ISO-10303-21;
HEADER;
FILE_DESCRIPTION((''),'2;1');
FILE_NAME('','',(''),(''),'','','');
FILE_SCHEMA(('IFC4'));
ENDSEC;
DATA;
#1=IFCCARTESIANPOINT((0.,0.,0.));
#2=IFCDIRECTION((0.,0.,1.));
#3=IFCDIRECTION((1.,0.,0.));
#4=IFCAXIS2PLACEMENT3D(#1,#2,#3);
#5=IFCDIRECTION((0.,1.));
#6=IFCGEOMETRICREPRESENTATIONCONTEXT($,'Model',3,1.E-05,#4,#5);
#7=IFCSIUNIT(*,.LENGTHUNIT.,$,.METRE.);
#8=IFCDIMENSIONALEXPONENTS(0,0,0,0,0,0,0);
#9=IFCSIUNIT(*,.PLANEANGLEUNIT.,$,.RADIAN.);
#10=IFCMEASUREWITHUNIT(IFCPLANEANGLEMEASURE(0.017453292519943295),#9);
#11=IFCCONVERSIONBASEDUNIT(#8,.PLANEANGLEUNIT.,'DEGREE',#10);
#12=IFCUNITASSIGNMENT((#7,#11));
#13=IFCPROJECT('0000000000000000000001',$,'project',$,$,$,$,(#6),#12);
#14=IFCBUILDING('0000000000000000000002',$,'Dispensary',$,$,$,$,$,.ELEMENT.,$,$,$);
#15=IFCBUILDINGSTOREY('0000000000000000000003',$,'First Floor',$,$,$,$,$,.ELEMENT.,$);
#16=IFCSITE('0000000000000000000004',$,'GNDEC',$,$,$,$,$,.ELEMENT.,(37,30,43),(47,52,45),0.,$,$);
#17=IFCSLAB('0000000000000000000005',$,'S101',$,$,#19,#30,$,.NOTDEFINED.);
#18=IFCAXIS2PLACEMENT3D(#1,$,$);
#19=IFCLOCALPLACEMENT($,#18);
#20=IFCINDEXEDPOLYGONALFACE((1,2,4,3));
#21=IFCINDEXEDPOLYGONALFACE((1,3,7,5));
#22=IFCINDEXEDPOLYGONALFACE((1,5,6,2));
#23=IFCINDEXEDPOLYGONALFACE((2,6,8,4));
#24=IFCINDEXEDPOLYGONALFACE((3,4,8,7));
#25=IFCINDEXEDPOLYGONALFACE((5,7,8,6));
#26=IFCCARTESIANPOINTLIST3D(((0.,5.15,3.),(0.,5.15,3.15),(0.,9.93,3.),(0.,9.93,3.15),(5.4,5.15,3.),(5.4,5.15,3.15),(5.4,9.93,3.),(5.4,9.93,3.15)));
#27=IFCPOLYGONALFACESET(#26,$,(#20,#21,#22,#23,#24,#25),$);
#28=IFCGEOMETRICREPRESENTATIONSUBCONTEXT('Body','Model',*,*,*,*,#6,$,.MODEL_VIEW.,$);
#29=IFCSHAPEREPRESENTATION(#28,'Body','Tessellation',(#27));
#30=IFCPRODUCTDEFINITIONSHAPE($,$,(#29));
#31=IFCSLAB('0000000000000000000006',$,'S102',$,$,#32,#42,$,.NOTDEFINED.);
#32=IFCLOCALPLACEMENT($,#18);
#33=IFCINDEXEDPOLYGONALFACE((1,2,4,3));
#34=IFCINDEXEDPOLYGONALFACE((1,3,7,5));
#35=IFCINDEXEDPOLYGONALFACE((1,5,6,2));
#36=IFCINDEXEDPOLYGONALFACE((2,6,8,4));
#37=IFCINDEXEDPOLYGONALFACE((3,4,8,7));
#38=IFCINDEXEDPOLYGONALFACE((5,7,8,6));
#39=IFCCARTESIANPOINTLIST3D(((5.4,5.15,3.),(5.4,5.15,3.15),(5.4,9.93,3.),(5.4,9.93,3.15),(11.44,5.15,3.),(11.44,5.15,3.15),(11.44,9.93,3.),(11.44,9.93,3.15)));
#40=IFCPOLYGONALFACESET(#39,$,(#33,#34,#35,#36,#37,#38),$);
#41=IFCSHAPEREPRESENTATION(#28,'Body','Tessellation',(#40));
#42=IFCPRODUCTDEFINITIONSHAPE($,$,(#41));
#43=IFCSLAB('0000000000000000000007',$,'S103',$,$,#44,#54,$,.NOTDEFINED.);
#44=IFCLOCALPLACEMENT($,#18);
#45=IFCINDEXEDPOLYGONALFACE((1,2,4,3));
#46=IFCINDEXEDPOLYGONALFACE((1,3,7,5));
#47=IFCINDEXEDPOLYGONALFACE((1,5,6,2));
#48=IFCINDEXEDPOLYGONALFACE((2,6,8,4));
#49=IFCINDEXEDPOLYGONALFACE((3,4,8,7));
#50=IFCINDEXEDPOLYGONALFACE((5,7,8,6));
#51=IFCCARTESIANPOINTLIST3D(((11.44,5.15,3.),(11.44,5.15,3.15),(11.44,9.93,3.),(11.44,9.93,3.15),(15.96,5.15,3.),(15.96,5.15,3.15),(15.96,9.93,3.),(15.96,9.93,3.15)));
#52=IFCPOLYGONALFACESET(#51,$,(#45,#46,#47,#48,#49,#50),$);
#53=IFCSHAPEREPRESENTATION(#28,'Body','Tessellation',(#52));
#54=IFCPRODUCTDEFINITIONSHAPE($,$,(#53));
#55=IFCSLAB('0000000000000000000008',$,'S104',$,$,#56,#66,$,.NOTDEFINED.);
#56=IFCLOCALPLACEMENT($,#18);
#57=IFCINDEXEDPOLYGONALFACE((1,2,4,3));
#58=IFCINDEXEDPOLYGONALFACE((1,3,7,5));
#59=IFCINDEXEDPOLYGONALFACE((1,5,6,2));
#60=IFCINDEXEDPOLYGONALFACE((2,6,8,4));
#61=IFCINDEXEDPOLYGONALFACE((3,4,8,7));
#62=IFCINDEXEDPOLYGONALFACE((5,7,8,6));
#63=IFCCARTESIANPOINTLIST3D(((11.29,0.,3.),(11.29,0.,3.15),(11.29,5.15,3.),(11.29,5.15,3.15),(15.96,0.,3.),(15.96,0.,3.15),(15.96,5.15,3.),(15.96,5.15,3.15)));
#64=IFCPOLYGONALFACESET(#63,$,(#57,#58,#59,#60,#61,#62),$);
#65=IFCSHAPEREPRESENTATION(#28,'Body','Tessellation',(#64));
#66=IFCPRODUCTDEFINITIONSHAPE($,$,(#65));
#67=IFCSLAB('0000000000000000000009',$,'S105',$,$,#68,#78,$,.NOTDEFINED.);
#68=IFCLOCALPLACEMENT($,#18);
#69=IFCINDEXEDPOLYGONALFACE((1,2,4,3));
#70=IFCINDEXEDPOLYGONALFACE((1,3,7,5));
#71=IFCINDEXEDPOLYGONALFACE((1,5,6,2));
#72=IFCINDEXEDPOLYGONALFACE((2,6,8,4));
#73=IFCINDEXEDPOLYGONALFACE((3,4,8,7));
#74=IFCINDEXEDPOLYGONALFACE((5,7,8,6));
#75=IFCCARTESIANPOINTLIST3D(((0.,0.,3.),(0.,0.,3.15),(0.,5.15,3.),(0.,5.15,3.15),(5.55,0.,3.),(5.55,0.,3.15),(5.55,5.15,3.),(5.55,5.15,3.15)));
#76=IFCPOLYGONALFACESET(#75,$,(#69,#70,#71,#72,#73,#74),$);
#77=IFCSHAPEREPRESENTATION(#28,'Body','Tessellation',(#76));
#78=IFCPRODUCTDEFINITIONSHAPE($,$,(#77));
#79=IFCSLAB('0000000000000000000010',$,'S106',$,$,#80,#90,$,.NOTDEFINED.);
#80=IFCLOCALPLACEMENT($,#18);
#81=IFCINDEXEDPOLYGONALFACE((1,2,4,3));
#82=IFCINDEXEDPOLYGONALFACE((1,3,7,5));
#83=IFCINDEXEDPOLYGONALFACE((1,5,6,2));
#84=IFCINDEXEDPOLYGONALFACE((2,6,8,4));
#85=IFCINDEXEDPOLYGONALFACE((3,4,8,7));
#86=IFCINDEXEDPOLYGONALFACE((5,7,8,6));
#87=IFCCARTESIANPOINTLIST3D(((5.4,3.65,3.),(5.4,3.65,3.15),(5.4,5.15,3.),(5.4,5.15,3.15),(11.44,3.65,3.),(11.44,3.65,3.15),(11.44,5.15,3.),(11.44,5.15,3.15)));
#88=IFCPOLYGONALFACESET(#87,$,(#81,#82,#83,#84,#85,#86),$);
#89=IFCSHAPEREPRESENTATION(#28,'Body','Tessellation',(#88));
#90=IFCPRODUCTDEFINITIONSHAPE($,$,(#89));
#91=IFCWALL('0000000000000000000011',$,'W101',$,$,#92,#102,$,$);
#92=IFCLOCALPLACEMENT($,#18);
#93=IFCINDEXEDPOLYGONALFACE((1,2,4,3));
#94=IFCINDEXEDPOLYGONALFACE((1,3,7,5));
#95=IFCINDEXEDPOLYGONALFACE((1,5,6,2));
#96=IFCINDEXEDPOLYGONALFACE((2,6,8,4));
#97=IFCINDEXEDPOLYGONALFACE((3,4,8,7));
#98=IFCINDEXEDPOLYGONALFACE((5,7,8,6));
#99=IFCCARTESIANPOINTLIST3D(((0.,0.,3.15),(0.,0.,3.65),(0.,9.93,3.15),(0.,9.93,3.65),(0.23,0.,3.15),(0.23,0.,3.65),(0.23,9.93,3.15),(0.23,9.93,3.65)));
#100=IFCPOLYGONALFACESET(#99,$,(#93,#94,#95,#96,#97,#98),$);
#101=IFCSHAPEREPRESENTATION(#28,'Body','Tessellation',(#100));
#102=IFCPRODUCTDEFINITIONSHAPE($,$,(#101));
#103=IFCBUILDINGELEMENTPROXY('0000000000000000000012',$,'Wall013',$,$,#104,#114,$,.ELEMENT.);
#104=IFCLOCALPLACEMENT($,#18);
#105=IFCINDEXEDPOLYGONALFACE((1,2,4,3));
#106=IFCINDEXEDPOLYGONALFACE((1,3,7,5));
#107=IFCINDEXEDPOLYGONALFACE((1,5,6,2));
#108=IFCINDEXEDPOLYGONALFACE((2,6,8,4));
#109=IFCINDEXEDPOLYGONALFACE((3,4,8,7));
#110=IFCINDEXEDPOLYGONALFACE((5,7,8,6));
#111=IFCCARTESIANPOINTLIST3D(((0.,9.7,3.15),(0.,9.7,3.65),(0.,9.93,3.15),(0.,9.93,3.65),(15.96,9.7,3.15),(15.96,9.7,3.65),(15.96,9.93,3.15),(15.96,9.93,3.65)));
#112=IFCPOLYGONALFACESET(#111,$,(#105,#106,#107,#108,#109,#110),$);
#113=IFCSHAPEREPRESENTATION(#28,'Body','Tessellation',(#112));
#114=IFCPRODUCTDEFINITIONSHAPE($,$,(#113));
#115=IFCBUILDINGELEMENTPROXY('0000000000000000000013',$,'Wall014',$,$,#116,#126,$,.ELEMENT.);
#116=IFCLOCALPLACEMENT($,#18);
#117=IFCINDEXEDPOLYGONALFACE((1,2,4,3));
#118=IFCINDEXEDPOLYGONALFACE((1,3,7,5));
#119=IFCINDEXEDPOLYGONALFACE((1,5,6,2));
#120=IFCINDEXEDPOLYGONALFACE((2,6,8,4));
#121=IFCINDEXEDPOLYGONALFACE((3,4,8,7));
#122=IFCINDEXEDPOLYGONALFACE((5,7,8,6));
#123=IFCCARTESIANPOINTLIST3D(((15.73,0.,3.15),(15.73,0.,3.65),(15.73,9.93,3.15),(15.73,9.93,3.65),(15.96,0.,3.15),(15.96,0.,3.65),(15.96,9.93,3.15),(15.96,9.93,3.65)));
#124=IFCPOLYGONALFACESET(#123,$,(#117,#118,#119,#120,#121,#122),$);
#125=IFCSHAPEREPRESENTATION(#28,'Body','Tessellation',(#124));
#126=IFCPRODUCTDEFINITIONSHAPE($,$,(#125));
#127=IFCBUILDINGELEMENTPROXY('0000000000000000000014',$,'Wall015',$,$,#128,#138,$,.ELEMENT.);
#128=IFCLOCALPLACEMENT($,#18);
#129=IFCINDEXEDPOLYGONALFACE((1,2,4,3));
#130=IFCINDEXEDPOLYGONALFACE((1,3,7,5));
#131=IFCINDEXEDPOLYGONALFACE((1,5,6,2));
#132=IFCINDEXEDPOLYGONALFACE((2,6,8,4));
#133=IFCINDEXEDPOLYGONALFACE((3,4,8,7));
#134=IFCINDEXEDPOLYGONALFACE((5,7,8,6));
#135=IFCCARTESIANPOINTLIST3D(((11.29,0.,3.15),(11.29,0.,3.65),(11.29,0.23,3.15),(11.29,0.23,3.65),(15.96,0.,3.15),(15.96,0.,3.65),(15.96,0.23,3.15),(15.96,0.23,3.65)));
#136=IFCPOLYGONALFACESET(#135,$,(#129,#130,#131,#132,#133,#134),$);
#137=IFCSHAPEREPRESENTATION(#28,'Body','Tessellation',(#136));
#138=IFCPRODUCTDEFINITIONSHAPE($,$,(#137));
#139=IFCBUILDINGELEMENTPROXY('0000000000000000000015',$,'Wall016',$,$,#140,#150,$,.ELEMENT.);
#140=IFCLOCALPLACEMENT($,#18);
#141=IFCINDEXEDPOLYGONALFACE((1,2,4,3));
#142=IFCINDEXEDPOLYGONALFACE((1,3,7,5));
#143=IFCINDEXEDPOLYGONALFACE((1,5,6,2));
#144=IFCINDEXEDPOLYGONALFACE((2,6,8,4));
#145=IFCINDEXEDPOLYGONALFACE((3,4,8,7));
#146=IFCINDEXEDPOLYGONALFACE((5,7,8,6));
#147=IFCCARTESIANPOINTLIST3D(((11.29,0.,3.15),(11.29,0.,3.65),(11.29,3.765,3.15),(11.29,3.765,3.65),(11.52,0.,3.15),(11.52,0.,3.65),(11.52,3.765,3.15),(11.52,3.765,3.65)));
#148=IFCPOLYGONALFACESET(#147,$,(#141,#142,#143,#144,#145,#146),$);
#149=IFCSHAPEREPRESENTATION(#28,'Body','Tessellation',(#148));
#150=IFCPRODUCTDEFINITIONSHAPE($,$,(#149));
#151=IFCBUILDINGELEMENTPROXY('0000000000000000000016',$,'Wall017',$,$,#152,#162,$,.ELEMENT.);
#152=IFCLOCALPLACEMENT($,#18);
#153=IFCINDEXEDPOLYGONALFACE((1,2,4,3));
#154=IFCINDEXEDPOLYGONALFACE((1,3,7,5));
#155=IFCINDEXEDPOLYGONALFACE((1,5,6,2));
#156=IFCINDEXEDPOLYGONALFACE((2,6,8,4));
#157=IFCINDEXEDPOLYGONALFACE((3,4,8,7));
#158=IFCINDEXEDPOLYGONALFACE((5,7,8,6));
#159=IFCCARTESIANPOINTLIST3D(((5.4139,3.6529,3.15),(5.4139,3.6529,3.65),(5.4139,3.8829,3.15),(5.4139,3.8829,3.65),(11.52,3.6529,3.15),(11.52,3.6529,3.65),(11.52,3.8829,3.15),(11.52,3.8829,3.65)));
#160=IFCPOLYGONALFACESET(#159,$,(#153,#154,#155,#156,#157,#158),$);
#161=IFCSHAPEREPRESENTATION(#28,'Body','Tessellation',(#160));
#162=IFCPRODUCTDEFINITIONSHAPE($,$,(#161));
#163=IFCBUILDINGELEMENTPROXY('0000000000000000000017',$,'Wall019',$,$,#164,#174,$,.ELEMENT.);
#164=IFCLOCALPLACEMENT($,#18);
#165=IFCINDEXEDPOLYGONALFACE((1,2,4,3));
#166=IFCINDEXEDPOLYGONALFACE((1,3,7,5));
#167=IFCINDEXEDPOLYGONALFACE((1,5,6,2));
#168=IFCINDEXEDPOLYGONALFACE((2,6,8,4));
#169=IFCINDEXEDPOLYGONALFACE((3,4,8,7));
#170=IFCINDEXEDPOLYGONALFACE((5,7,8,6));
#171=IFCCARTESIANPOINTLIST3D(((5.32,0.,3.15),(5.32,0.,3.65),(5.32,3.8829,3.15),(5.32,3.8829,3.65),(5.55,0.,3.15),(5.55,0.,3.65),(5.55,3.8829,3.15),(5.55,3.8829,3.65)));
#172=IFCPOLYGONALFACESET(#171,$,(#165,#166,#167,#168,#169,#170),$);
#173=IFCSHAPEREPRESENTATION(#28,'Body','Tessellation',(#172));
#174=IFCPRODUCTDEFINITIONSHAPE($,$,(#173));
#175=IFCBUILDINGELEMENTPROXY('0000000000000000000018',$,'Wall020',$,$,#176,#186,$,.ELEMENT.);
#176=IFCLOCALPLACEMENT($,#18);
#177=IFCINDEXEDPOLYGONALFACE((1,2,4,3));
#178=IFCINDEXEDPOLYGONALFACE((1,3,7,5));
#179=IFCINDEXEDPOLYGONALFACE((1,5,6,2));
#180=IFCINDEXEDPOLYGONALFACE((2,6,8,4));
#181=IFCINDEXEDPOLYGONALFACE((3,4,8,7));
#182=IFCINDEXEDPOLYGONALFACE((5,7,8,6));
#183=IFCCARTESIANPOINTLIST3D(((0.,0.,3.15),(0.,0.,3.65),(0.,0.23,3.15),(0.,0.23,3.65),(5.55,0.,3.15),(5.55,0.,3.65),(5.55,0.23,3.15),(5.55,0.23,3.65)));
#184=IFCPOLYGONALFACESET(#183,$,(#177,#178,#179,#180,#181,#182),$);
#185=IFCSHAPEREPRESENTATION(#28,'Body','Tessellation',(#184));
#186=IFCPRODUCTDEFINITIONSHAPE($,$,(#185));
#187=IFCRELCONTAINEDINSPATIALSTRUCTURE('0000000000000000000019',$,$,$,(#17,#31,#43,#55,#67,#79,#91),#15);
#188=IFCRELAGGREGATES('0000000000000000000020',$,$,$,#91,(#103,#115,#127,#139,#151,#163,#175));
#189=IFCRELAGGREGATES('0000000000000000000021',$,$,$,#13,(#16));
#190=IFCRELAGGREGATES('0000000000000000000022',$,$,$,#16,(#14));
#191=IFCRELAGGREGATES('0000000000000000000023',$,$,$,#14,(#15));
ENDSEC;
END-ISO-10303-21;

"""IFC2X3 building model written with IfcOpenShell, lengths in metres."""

from ifc_helpers import new_model, entity, si_unit, converted_unit, direction, frame, frame_2d, origin_with_axes, origin_2d_with_axis, place, context, subcontext, project, spatial, rectangle, extrude, element, aggregate, save


model = new_model("IFC2X3")

# Units and contexts
model_context = context("Model", 3, precision=1e-05, world=origin_with_axes(), true_north=direction((0.0, 1.0)))
body_context = subcontext(model_context, "Body", "Model", "MODEL_VIEW")
ifc_project = project(units=[si_unit("LENGTHUNIT", "METRE"), converted_unit("PLANEANGLEUNIT", "DEGREE", entity("IfcPlaneAngleMeasure", 0.017453292519943295), si_unit("PLANEANGLEUNIT", "RADIAN"), dimensions=[0, 0, 0, 0, 0, 0, 0])], contexts=[model_context])

# Site, building, storey
site = spatial("IfcSite", under=ifc_project, Name="GNDEC", CompositionType="ELEMENT", RefLatitude=(37, 30, 43), RefLongitude=(47, 52, 45), RefElevation=0.0)
building = spatial("IfcBuilding", under=site, Name="Dispensary", CompositionType="ELEMENT")
storey = spatial("IfcBuildingStorey", under=building, Name="First Floor", CompositionType="ELEMENT")

# Slabs
placement = place(None, origin_with_axes())
element("IfcSlab", 1, at=placement, inside=storey, Name="S101", PredefinedType="NOTDEFINED", context=body_context, shape_type="SweptSolid", body=[
    extrude(rectangle(XDim=5.4, YDim=4.78, at=frame_2d((0.0, 0.0), x_axis=(-1.0, 0.0))), frame((2.7, 7.54, 3.0), z_axis=(0.0, 0.0, 1.0), x_axis=(1.0, 0.0, 0.0)), (0.0, 0.0, 1.0), 0.15),
])
element("IfcSlab", 2, at=placement, inside=storey, Name="S102", PredefinedType="NOTDEFINED", context=body_context, shape_type="SweptSolid", body=[
    extrude(rectangle(XDim=6.04, YDim=4.78, at=frame_2d((0.0, 0.0), x_axis=(-1.0, 0.0))), frame((8.42, 7.54, 3.0), z_axis=(0.0, 0.0, 1.0), x_axis=(1.0, 0.0, 0.0)), (0.0, 0.0, 1.0), 0.15),
])
element("IfcSlab", 3, at=placement, inside=storey, Name="S103", PredefinedType="NOTDEFINED", context=body_context, shape_type="SweptSolid", body=[
    extrude(rectangle(XDim=4.52, YDim=4.78, at=frame_2d((0.0, 0.0), x_axis=(-1.0, 0.0))), frame((13.7, 7.54, 3.0), z_axis=(0.0, 0.0, 1.0), x_axis=(1.0, 0.0, 0.0)), (0.0, 0.0, 1.0), 0.15),
])
element("IfcSlab", 4, at=placement, inside=storey, Name="S104", PredefinedType="NOTDEFINED", context=body_context, shape_type="SweptSolid", body=[
    extrude(rectangle(XDim=4.67, YDim=5.15, at=frame_2d((0.0, 0.0), x_axis=(-1.0, 0.0))), frame((13.625, 2.575, 3.0), z_axis=(0.0, 0.0, 1.0), x_axis=(1.0, 0.0, 0.0)), (0.0, 0.0, 1.0), 0.15),
])
element("IfcSlab", 5, at=placement, inside=storey, Name="S105", PredefinedType="NOTDEFINED", context=body_context, shape_type="SweptSolid", body=[
    extrude(rectangle(XDim=5.55, YDim=5.15, at=frame_2d((0.0, 0.0), x_axis=(-1.0, 0.0))), frame((2.775, 2.575, 3.0), z_axis=(0.0, 0.0, 1.0), x_axis=(1.0, 0.0, 0.0)), (0.0, 0.0, 1.0), 0.15),
])
element("IfcSlab", 6, at=placement, inside=storey, Name="S106", PredefinedType="NOTDEFINED", context=body_context, shape_type="SweptSolid", body=[
    extrude(rectangle(XDim=6.04, YDim=1.5, at=frame_2d((0.0, 0.0), x_axis=(-1.0, 0.0))), frame((8.42, 4.4, 3.0), z_axis=(0.0, 0.0, 1.0), x_axis=(1.0, 0.0, 0.0)), (0.0, 0.0, 1.0), 0.15),
])

# Wall, building element proxies
wall = element("IfcWall", 7, at=placement, inside=storey, Name="W101", context=body_context, shape_type="SweptSolid", body=[
    extrude(rectangle(XDim=9.93, YDim=0.23, at=frame_2d((0.0, 0.0), x_axis=(0.0, -1.0))), frame((0.115, 4.965, 3.15), z_axis=(0.0, 0.0, 1.0), x_axis=(1.0, 0.0, 0.0)), (0.0, 0.0, 1.0), 0.5),
])
proxy_1 = element("IfcBuildingElementProxy", 8, at=placement, Name="Wall013", CompositionType="ELEMENT", context=body_context, shape_type="SweptSolid", body=[
    extrude(rectangle(XDim=15.96, YDim=0.23, at=frame_2d((0.0, 0.0), x_axis=(-1.0, 0.0))), frame((7.98, 9.815, 3.15), z_axis=(0.0, 0.0, 1.0), x_axis=(1.0, 0.0, 0.0)), (0.0, 0.0, 1.0), 0.5),
])
proxy_2 = element("IfcBuildingElementProxy", 9, at=placement, Name="Wall014", CompositionType="ELEMENT", context=body_context, shape_type="SweptSolid", body=[
    extrude(rectangle(XDim=9.93, YDim=0.23, at=frame_2d((0.0, 0.0), x_axis=(0.0, 1.0))), frame((15.845, 4.965, 3.15), z_axis=(0.0, 0.0, 1.0), x_axis=(1.0, 0.0, 0.0)), (0.0, 0.0, 1.0), 0.5),
])
proxy_3 = element("IfcBuildingElementProxy", 10, at=placement, Name="Wall015", CompositionType="ELEMENT", context=body_context, shape_type="SweptSolid", body=[
    extrude(rectangle(XDim=4.67, YDim=0.23, at=frame_2d((0.0, 0.0), x_axis=(1.0, 0.0))), frame((13.625, 0.115, 3.15), z_axis=(0.0, 0.0, 1.0), x_axis=(1.0, 0.0, 0.0)), (0.0, 0.0, 1.0), 0.5),
])
proxy_4 = element("IfcBuildingElementProxy", 11, at=placement, Name="Wall016", CompositionType="ELEMENT", context=body_context, shape_type="SweptSolid", body=[
    extrude(rectangle(XDim=3.765, YDim=0.23, at=frame_2d((0.0, 0.0), x_axis=(0.0, -1.0))), frame((11.405, 1.8825, 3.15), z_axis=(0.0, 0.0, 1.0), x_axis=(1.0, 0.0, 0.0)), (0.0, 0.0, 1.0), 0.5),
])
proxy_5 = element("IfcBuildingElementProxy", 12, at=placement, Name="Wall017", CompositionType="ELEMENT", context=body_context, shape_type="SweptSolid", body=[
    extrude(rectangle(XDim=6.1061, YDim=0.23, at=frame_2d((0.0, 0.0), x_axis=(1.0, 0.0))), frame((8.4669, 3.7679, 3.15), z_axis=(0.0, 0.0, 1.0), x_axis=(1.0, 0.0, 0.0)), (0.0, 0.0, 1.0), 0.5),
])
proxy_6 = element("IfcBuildingElementProxy", 13, at=placement, Name="Wall019", CompositionType="ELEMENT", context=body_context, shape_type="SweptSolid", body=[
    extrude(rectangle(XDim=3.8829, YDim=0.23, at=frame_2d((0.0, 0.0), x_axis=(0.0, 1.0))), frame((5.435, 1.9414, 3.15), z_axis=(0.0, 0.0, 1.0), x_axis=(1.0, 0.0, 0.0)), (0.0, 0.0, 1.0), 0.5),
])
proxy_7 = element("IfcBuildingElementProxy", 14, at=placement, Name="Wall020", CompositionType="ELEMENT", context=body_context, shape_type="SweptSolid", body=[
    extrude(rectangle(XDim=5.55, YDim=0.23, at=origin_2d_with_axis()), frame((2.775, 0.115, 3.15), z_axis=(0.0, 0.0, 1.0), x_axis=(1.0, 0.0, 0.0)), (0.0, 0.0, 1.0), 0.5),
])
aggregate(wall, [proxy_1, proxy_2, proxy_3, proxy_4, proxy_5, proxy_6, proxy_7])

save(model, "model.ifc")
